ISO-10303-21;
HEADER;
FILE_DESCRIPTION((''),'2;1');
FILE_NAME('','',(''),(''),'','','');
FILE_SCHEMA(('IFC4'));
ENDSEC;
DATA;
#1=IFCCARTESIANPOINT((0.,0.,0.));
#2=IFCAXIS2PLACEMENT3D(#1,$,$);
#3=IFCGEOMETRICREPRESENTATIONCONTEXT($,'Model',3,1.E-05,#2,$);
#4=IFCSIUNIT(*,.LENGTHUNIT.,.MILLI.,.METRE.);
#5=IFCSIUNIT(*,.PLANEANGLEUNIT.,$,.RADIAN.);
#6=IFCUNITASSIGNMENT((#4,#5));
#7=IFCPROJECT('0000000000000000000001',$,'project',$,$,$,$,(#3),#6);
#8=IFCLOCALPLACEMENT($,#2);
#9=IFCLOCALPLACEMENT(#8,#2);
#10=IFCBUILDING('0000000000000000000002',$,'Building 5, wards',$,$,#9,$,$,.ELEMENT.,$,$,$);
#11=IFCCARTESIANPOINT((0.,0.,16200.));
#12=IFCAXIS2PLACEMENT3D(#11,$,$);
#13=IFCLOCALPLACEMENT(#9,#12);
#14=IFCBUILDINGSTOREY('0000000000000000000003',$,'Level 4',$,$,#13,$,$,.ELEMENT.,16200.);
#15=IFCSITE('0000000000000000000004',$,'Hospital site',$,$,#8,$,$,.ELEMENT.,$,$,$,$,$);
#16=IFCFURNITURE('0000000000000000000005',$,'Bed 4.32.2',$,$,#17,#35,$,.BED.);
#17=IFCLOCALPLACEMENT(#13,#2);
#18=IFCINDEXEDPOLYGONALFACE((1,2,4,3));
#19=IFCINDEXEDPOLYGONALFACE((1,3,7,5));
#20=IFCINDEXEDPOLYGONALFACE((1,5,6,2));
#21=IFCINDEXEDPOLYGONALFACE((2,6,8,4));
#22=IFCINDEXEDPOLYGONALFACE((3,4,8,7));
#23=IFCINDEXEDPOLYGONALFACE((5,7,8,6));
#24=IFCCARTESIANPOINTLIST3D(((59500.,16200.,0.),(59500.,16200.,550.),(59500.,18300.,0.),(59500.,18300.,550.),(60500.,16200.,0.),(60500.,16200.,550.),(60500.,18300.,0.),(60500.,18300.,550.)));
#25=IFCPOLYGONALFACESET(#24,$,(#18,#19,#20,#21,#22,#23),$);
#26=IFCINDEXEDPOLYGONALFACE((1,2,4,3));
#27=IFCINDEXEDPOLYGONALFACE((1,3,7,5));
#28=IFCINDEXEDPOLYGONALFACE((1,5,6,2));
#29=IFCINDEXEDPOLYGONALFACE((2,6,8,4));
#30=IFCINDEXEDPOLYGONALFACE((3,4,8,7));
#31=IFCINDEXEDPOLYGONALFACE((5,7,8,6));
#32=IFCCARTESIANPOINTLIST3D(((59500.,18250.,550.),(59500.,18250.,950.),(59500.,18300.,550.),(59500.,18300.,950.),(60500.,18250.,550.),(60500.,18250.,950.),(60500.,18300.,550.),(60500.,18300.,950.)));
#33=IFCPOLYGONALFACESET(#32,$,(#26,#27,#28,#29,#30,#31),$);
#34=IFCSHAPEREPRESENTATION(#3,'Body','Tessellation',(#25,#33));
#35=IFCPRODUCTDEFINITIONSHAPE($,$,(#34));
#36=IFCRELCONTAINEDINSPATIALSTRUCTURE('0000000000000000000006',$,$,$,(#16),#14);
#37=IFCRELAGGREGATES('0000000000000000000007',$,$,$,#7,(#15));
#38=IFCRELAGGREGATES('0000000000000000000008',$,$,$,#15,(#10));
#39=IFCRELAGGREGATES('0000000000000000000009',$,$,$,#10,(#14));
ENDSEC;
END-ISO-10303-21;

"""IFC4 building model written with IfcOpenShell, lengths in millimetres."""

from ifc_helpers import new_model, si_unit, frame, frame_2d, origin, place, context, project, spatial, rectangle, extrude, element, save


model = new_model("IFC4")

# Units and contexts
model_context = context("Model", 3, precision=1e-05, world=origin())
ifc_project = project(units=[si_unit("LENGTHUNIT", "METRE", prefix="MILLI"), si_unit("PLANEANGLEUNIT", "RADIAN")], contexts=[model_context])

# Site, building, storey
site_placement = place(None, origin())
site = spatial("IfcSite", under=ifc_project, at=site_placement, Name="Hospital site", CompositionType="ELEMENT")
building_placement = place(site_placement, origin())
building = spatial("IfcBuilding", under=site, at=building_placement, Name="Building 5, wards", CompositionType="ELEMENT")
storey_placement = place(building_placement, frame((0.0, 0.0, 16200.0)))
storey = spatial("IfcBuildingStorey", under=building, at=storey_placement, Name="Level 4", CompositionType="ELEMENT", Elevation=16200.0)

# Furniture
furniture_placement = place(storey_placement, frame((59500.0, 16200.0, 0.0)))
element("IfcFurniture", 1, at=furniture_placement, inside=storey, Name="Bed 4.32.2", PredefinedType="BED", context=model_context, shape_type="SweptSolid", body=[
    extrude(rectangle(XDim=1000.0, YDim=2100.0, at=frame_2d((500.0, 1050.0))), origin(), (0.0, 0.0, 1.0), 550.0),
    extrude(rectangle(XDim=1000.0, YDim=50.0, at=frame_2d((500.0, 2075.0))), frame((0.0, 0.0, 550.0)), (0.0, 0.0, 1.0), 400.0),
])

save(model, "model.ifc")
